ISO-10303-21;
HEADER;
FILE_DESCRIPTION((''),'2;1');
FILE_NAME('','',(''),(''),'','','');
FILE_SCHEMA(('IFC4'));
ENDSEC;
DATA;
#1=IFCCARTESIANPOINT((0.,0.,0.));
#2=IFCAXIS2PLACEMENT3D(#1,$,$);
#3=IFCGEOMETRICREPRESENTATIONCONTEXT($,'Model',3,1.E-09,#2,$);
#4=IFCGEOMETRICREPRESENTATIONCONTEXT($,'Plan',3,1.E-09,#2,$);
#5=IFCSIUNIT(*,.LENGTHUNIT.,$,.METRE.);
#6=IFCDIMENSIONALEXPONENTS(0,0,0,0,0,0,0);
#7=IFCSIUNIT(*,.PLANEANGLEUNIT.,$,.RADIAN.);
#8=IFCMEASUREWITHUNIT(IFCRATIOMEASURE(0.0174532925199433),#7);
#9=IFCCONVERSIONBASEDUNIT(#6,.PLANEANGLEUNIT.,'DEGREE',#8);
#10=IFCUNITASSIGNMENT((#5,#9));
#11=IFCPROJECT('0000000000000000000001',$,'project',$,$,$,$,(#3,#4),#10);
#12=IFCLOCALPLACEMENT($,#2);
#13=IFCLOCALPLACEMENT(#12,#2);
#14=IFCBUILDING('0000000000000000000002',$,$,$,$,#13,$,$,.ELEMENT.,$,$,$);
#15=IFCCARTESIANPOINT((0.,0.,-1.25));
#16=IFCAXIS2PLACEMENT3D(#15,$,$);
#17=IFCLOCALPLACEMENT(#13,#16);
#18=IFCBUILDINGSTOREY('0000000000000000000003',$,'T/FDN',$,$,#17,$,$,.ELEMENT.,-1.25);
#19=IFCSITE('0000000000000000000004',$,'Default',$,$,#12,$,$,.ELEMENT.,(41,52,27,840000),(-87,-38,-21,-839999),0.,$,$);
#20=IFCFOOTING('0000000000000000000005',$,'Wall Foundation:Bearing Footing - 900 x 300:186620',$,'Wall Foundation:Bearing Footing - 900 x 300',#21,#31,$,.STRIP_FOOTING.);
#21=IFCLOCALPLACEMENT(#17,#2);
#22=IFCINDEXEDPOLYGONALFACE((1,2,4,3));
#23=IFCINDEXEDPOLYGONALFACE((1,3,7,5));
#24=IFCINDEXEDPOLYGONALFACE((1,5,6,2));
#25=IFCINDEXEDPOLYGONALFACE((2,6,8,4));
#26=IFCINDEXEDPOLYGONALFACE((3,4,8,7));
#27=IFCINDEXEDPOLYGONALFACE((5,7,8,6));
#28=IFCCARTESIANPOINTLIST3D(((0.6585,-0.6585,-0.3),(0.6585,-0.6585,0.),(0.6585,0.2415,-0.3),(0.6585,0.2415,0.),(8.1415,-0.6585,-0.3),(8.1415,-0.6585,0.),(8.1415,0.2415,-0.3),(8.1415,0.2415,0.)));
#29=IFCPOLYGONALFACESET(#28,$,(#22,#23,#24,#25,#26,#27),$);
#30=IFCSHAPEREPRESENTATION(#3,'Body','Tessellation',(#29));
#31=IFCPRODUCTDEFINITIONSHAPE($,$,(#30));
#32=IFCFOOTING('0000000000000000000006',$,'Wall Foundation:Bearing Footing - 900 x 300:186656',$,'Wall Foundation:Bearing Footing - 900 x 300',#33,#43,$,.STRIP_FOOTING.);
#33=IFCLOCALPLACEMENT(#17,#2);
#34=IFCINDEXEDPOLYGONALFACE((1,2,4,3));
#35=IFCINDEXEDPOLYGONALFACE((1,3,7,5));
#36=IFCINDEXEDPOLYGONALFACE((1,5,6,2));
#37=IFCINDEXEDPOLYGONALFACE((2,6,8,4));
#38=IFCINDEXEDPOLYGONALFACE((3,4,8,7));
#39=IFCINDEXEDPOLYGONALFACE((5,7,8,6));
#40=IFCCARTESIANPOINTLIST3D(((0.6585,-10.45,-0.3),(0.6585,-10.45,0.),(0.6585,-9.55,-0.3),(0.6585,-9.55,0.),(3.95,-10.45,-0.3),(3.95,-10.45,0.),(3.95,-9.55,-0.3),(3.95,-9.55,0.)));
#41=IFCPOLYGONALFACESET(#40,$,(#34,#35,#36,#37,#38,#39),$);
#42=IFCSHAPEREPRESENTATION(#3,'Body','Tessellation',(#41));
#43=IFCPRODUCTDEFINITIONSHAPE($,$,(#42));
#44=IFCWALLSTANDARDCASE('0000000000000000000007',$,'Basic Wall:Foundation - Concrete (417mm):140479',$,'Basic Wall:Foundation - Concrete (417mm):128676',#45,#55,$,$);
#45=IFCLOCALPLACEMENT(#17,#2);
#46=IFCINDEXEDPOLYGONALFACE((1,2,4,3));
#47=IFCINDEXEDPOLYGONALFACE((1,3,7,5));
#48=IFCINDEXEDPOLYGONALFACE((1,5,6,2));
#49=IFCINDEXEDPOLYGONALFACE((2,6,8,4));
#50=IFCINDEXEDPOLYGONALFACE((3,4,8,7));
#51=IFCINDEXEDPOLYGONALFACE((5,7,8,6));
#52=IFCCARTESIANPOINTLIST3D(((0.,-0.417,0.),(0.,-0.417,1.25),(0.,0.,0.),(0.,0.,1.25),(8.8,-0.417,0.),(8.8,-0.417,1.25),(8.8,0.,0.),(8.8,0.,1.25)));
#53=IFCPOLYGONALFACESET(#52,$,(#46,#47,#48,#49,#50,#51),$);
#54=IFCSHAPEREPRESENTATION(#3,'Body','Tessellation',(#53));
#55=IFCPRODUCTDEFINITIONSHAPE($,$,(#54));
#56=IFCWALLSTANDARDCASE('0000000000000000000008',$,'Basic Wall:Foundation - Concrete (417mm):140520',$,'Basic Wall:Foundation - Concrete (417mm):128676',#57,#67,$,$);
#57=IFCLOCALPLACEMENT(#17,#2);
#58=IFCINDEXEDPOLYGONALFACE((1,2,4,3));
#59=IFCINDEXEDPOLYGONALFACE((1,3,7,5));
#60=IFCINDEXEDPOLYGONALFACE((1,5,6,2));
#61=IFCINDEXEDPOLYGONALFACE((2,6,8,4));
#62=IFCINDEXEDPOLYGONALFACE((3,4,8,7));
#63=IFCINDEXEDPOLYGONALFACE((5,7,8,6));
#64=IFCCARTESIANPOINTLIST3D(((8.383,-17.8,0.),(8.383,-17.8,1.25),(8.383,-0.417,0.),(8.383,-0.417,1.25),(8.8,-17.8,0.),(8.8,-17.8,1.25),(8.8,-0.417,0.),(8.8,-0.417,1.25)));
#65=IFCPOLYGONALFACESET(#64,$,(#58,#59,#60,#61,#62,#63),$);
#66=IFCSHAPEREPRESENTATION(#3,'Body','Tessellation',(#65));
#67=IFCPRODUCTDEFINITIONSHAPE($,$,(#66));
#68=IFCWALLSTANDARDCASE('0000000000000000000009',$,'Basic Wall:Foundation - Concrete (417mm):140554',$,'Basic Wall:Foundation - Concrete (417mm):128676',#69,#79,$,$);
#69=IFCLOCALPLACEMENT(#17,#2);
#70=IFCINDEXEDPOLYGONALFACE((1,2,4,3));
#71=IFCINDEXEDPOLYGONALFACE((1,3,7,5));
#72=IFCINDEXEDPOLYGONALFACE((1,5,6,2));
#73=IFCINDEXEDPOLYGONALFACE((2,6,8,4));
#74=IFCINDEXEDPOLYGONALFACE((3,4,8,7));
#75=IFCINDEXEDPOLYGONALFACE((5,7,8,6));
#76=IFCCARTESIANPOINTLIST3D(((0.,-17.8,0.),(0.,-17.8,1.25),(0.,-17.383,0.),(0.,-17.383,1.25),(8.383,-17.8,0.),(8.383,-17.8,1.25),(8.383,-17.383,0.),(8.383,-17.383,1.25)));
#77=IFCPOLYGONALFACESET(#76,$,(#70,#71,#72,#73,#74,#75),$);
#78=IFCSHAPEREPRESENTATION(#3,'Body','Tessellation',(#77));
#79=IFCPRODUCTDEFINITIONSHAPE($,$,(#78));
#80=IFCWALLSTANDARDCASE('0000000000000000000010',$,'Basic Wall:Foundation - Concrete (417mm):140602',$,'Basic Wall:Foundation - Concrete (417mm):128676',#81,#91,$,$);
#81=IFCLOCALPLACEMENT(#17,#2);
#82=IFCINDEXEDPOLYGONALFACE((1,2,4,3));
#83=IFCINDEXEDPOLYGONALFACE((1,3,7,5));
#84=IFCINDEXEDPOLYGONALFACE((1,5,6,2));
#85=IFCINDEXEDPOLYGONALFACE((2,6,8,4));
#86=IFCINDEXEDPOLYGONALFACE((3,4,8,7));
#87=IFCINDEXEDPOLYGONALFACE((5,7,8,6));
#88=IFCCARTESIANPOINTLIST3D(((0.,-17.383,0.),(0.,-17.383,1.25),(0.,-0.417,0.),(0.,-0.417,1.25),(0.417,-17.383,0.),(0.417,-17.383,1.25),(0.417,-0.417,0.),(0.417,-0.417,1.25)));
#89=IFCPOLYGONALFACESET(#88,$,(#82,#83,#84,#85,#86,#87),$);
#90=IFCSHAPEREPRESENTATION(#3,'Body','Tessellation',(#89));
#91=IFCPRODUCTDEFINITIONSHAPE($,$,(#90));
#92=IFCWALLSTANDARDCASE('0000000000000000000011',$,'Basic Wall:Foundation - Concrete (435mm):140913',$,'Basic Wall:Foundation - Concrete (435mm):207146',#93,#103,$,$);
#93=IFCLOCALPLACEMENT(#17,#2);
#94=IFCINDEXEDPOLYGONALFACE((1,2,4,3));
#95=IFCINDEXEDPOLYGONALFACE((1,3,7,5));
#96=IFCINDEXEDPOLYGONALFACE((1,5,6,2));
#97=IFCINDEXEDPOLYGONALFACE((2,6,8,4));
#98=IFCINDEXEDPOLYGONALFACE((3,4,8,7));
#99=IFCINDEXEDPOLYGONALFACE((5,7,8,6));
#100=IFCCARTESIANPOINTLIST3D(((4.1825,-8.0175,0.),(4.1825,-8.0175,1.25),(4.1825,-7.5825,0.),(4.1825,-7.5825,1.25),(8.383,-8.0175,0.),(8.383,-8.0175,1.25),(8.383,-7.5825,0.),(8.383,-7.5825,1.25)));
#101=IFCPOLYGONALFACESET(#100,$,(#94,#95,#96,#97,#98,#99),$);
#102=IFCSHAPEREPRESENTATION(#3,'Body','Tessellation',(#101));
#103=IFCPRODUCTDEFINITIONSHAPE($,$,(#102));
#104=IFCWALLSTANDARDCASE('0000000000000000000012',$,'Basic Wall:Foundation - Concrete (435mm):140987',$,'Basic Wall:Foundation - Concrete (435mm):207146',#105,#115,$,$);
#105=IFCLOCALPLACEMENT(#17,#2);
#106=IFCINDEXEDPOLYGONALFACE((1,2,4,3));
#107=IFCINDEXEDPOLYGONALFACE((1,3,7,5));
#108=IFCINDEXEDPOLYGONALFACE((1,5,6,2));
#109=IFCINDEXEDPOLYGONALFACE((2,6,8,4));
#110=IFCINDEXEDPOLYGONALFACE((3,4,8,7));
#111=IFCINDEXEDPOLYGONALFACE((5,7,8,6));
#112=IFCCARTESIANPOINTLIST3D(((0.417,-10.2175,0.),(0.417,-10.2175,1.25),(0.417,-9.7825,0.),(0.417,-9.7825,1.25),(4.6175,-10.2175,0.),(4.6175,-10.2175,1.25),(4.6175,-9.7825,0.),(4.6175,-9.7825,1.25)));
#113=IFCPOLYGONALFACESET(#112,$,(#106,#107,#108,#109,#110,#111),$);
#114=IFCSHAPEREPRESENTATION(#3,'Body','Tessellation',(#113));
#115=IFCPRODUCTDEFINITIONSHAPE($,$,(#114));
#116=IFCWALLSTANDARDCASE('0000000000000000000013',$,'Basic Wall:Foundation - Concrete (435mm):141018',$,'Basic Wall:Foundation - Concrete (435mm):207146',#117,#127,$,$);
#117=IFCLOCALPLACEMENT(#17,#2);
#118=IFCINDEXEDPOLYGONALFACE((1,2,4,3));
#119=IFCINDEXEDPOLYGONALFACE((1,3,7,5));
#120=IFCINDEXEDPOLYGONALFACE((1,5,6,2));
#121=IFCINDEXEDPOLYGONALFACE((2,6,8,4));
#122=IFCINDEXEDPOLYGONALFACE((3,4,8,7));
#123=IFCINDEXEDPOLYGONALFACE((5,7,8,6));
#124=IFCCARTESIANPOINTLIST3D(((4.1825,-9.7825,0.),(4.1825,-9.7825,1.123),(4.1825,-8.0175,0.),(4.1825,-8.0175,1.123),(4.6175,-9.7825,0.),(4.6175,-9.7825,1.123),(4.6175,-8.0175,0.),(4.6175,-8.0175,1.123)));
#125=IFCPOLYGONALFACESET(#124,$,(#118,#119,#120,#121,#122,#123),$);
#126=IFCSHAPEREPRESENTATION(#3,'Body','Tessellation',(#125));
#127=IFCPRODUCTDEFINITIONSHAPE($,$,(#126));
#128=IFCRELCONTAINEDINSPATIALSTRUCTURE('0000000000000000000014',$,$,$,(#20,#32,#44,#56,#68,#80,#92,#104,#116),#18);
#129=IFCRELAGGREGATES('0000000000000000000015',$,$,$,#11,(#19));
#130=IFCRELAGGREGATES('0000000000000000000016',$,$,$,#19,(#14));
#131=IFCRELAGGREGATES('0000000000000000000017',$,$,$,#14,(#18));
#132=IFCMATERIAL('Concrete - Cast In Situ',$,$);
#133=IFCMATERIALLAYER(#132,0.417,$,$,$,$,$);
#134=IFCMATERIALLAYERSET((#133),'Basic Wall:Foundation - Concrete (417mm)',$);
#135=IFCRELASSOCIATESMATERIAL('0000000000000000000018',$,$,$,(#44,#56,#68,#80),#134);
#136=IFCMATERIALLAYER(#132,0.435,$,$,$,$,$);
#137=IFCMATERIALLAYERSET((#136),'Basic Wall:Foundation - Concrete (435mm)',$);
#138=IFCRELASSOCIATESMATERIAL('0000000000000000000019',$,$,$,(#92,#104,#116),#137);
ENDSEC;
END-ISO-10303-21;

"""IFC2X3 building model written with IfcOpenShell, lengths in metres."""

from ifc_helpers import new_model, entity, si_unit, converted_unit, frame, frame_2d, origin, origin_2d_with_axis, place, context, project, spatial, rectangle, extrude, material, layer, layer_set, layer_usage, element, save


model = new_model("IFC2X3")

# Units and contexts
model_context = context("Model", 3, precision=1e-09, world=origin())
plan_context = context("Plan", 3, precision=1e-09, world=origin())
ifc_project = project(units=[si_unit("LENGTHUNIT", "METRE"), converted_unit("PLANEANGLEUNIT", "DEGREE", entity("IfcRatioMeasure", 0.0174532925199433), si_unit("PLANEANGLEUNIT", "RADIAN"), dimensions=[0, 0, 0, 0, 0, 0, 0])], contexts=[model_context, plan_context])

# Site, building, storey
site_placement = place(None, origin())
site = spatial("IfcSite", under=ifc_project, at=site_placement, Name="Default", CompositionType="ELEMENT", RefLatitude=(41, 52, 27, 840000), RefLongitude=(-87, -38, -21, -839999), RefElevation=0.0)
building_placement = place(site_placement, origin())
building = spatial("IfcBuilding", under=site, at=building_placement, CompositionType="ELEMENT")
storey_placement = place(building_placement, frame((0.0, 0.0, -1.25)))
storey = spatial("IfcBuildingStorey", under=building, at=storey_placement, Name="T/FDN", CompositionType="ELEMENT", Elevation=-1.25)

# Footings
footing_1_placement = place(storey_placement, origin())
element("IfcFooting", 1, at=footing_1_placement, inside=storey, Name="Wall Foundation:Bearing Footing - 900 x 300:186620", ObjectType="Wall Foundation:Bearing Footing - 900 x 300", PredefinedType="STRIP_FOOTING", context=model_context, shape_type="SweptSolid", body=[
    extrude(rectangle(XDim=7.483, YDim=0.9, at=origin_2d_with_axis()), frame((4.4, -0.2085, -0.3), z_axis=(0.0, 0.0, 1.0), x_axis=(-1.0, 0.0, 0.0)), (0.0, 0.0, 1.0), 0.3),
])
footing_2_placement = place(storey_placement, origin())
element("IfcFooting", 2, at=footing_2_placement, inside=storey, Name="Wall Foundation:Bearing Footing - 900 x 300:186656", ObjectType="Wall Foundation:Bearing Footing - 900 x 300", PredefinedType="STRIP_FOOTING", context=model_context, shape_type="SweptSolid", body=[
    extrude(rectangle(XDim=3.2915, YDim=0.9, at=origin_2d_with_axis()), frame((2.3043, -10.0, -0.3)), (0.0, 0.0, 1.0), 0.3),
])

# Walls
ifc_material = material(Name="Concrete - Cast In Situ")
ifc_layer_1 = layer(ifc_material, 0.417)
ifc_layer_set_1 = layer_set([ifc_layer_1], Name="Basic Wall:Foundation - Concrete (417mm)")
ifc_layer_usage_1 = layer_usage(ifc_layer_set_1, "AXIS2", "NEGATIVE", 0.2085)
wall_1_placement = place(storey_placement, frame((0.0, -0.2085, 0.0)))
element("IfcWallStandardCase", 3, at=wall_1_placement, inside=storey, material=ifc_layer_usage_1, Name="Basic Wall:Foundation - Concrete (417mm):140479", ObjectType="Basic Wall:Foundation - Concrete (417mm):128676", context=model_context, shape_type="SweptSolid", body=[
    extrude(rectangle(XDim=8.8, YDim=0.417, at=frame_2d((4.4, 0.0), x_axis=(-1.0, 0.0))), origin(), (0.0, 0.0, 1.0), 1.25),
])
ifc_layer_usage_2 = layer_usage(ifc_layer_set_1, "AXIS2", "NEGATIVE", 0.2085)
wall_2_placement = place(storey_placement, frame((8.5915, -0.417, 0.0), z_axis=(0.0, 0.0, 1.0), x_axis=(0.0, -1.0, 0.0)))
element("IfcWallStandardCase", 4, at=wall_2_placement, inside=storey, material=ifc_layer_usage_2, Name="Basic Wall:Foundation - Concrete (417mm):140520", ObjectType="Basic Wall:Foundation - Concrete (417mm):128676", context=model_context, shape_type="SweptSolid", body=[
    extrude(rectangle(XDim=17.383, YDim=0.417, at=frame_2d((8.6915, 0.0), x_axis=(-1.0, 0.0))), origin(), (0.0, 0.0, 1.0), 1.25),
])
ifc_layer_usage_3 = layer_usage(ifc_layer_set_1, "AXIS2", "NEGATIVE", 0.2085)
wall_3_placement = place(storey_placement, frame((8.383, -17.5915, 0.0), z_axis=(0.0, 0.0, 1.0), x_axis=(-1.0, 0.0, 0.0)))
element("IfcWallStandardCase", 5, at=wall_3_placement, inside=storey, material=ifc_layer_usage_3, Name="Basic Wall:Foundation - Concrete (417mm):140554", ObjectType="Basic Wall:Foundation - Concrete (417mm):128676", context=model_context, shape_type="SweptSolid", body=[
    extrude(rectangle(XDim=8.383, YDim=0.417, at=frame_2d((4.1915, 0.0), x_axis=(-1.0, 0.0))), origin(), (0.0, 0.0, 1.0), 1.25),
])
ifc_layer_usage_4 = layer_usage(ifc_layer_set_1, "AXIS2", "NEGATIVE", 0.2085)
wall_4_placement = place(storey_placement, frame((0.2085, -17.383, 0.0), z_axis=(0.0, 0.0, 1.0), x_axis=(0.0, 1.0, 0.0)))
element("IfcWallStandardCase", 6, at=wall_4_placement, inside=storey, material=ifc_layer_usage_4, Name="Basic Wall:Foundation - Concrete (417mm):140602", ObjectType="Basic Wall:Foundation - Concrete (417mm):128676", context=model_context, shape_type="SweptSolid", body=[
    extrude(rectangle(XDim=16.966, YDim=0.417, at=frame_2d((8.483, 0.0), x_axis=(-1.0, 0.0))), origin(), (0.0, 0.0, 1.0), 1.25),
])
ifc_layer_2 = layer(ifc_material, 0.435)
ifc_layer_set_2 = layer_set([ifc_layer_2], Name="Basic Wall:Foundation - Concrete (435mm)")
ifc_layer_usage_5 = layer_usage(ifc_layer_set_2, "AXIS2", "NEGATIVE", 0.2175)
wall_5_placement = place(storey_placement, frame((8.383, -7.8, 0.0), z_axis=(0.0, 0.0, 1.0), x_axis=(-1.0, 0.0, 0.0)))
element("IfcWallStandardCase", 7, at=wall_5_placement, inside=storey, material=ifc_layer_usage_5, Name="Basic Wall:Foundation - Concrete (435mm):140913", ObjectType="Basic Wall:Foundation - Concrete (435mm):207146", context=model_context, shape_type="SweptSolid", body=[
    extrude(rectangle(XDim=4.2005, YDim=0.435, at=frame_2d((2.1002, 0.0), x_axis=(-1.0, 0.0))), origin(), (0.0, 0.0, 1.0), 1.25),
])
ifc_layer_usage_6 = layer_usage(ifc_layer_set_2, "AXIS2", "NEGATIVE", 0.2175)
wall_6_placement = place(storey_placement, frame((0.417, -10.0, 0.0)))
element("IfcWallStandardCase", 8, at=wall_6_placement, inside=storey, material=ifc_layer_usage_6, Name="Basic Wall:Foundation - Concrete (435mm):140987", ObjectType="Basic Wall:Foundation - Concrete (435mm):207146", context=model_context, shape_type="SweptSolid", body=[
    extrude(rectangle(XDim=4.2005, YDim=0.435, at=frame_2d((2.1002, 0.0), x_axis=(-1.0, 0.0))), origin(), (0.0, 0.0, 1.0), 1.25),
])
ifc_layer_usage_7 = layer_usage(ifc_layer_set_2, "AXIS2", "NEGATIVE", 0.2175)
wall_7_placement = place(storey_placement, frame((4.4, -9.7825, 0.0), z_axis=(0.0, 0.0, 1.0), x_axis=(0.0, 1.0, 0.0)))
element("IfcWallStandardCase", 9, at=wall_7_placement, inside=storey, material=ifc_layer_usage_7, Name="Basic Wall:Foundation - Concrete (435mm):141018", ObjectType="Basic Wall:Foundation - Concrete (435mm):207146", context=model_context, shape_type="SweptSolid", body=[
    extrude(rectangle(XDim=1.765, YDim=0.435, at=frame_2d((0.8825, 0.0), x_axis=(-1.0, 0.0))), origin(), (0.0, 0.0, 1.0), 1.123),
])

save(model, "model.ifc")
